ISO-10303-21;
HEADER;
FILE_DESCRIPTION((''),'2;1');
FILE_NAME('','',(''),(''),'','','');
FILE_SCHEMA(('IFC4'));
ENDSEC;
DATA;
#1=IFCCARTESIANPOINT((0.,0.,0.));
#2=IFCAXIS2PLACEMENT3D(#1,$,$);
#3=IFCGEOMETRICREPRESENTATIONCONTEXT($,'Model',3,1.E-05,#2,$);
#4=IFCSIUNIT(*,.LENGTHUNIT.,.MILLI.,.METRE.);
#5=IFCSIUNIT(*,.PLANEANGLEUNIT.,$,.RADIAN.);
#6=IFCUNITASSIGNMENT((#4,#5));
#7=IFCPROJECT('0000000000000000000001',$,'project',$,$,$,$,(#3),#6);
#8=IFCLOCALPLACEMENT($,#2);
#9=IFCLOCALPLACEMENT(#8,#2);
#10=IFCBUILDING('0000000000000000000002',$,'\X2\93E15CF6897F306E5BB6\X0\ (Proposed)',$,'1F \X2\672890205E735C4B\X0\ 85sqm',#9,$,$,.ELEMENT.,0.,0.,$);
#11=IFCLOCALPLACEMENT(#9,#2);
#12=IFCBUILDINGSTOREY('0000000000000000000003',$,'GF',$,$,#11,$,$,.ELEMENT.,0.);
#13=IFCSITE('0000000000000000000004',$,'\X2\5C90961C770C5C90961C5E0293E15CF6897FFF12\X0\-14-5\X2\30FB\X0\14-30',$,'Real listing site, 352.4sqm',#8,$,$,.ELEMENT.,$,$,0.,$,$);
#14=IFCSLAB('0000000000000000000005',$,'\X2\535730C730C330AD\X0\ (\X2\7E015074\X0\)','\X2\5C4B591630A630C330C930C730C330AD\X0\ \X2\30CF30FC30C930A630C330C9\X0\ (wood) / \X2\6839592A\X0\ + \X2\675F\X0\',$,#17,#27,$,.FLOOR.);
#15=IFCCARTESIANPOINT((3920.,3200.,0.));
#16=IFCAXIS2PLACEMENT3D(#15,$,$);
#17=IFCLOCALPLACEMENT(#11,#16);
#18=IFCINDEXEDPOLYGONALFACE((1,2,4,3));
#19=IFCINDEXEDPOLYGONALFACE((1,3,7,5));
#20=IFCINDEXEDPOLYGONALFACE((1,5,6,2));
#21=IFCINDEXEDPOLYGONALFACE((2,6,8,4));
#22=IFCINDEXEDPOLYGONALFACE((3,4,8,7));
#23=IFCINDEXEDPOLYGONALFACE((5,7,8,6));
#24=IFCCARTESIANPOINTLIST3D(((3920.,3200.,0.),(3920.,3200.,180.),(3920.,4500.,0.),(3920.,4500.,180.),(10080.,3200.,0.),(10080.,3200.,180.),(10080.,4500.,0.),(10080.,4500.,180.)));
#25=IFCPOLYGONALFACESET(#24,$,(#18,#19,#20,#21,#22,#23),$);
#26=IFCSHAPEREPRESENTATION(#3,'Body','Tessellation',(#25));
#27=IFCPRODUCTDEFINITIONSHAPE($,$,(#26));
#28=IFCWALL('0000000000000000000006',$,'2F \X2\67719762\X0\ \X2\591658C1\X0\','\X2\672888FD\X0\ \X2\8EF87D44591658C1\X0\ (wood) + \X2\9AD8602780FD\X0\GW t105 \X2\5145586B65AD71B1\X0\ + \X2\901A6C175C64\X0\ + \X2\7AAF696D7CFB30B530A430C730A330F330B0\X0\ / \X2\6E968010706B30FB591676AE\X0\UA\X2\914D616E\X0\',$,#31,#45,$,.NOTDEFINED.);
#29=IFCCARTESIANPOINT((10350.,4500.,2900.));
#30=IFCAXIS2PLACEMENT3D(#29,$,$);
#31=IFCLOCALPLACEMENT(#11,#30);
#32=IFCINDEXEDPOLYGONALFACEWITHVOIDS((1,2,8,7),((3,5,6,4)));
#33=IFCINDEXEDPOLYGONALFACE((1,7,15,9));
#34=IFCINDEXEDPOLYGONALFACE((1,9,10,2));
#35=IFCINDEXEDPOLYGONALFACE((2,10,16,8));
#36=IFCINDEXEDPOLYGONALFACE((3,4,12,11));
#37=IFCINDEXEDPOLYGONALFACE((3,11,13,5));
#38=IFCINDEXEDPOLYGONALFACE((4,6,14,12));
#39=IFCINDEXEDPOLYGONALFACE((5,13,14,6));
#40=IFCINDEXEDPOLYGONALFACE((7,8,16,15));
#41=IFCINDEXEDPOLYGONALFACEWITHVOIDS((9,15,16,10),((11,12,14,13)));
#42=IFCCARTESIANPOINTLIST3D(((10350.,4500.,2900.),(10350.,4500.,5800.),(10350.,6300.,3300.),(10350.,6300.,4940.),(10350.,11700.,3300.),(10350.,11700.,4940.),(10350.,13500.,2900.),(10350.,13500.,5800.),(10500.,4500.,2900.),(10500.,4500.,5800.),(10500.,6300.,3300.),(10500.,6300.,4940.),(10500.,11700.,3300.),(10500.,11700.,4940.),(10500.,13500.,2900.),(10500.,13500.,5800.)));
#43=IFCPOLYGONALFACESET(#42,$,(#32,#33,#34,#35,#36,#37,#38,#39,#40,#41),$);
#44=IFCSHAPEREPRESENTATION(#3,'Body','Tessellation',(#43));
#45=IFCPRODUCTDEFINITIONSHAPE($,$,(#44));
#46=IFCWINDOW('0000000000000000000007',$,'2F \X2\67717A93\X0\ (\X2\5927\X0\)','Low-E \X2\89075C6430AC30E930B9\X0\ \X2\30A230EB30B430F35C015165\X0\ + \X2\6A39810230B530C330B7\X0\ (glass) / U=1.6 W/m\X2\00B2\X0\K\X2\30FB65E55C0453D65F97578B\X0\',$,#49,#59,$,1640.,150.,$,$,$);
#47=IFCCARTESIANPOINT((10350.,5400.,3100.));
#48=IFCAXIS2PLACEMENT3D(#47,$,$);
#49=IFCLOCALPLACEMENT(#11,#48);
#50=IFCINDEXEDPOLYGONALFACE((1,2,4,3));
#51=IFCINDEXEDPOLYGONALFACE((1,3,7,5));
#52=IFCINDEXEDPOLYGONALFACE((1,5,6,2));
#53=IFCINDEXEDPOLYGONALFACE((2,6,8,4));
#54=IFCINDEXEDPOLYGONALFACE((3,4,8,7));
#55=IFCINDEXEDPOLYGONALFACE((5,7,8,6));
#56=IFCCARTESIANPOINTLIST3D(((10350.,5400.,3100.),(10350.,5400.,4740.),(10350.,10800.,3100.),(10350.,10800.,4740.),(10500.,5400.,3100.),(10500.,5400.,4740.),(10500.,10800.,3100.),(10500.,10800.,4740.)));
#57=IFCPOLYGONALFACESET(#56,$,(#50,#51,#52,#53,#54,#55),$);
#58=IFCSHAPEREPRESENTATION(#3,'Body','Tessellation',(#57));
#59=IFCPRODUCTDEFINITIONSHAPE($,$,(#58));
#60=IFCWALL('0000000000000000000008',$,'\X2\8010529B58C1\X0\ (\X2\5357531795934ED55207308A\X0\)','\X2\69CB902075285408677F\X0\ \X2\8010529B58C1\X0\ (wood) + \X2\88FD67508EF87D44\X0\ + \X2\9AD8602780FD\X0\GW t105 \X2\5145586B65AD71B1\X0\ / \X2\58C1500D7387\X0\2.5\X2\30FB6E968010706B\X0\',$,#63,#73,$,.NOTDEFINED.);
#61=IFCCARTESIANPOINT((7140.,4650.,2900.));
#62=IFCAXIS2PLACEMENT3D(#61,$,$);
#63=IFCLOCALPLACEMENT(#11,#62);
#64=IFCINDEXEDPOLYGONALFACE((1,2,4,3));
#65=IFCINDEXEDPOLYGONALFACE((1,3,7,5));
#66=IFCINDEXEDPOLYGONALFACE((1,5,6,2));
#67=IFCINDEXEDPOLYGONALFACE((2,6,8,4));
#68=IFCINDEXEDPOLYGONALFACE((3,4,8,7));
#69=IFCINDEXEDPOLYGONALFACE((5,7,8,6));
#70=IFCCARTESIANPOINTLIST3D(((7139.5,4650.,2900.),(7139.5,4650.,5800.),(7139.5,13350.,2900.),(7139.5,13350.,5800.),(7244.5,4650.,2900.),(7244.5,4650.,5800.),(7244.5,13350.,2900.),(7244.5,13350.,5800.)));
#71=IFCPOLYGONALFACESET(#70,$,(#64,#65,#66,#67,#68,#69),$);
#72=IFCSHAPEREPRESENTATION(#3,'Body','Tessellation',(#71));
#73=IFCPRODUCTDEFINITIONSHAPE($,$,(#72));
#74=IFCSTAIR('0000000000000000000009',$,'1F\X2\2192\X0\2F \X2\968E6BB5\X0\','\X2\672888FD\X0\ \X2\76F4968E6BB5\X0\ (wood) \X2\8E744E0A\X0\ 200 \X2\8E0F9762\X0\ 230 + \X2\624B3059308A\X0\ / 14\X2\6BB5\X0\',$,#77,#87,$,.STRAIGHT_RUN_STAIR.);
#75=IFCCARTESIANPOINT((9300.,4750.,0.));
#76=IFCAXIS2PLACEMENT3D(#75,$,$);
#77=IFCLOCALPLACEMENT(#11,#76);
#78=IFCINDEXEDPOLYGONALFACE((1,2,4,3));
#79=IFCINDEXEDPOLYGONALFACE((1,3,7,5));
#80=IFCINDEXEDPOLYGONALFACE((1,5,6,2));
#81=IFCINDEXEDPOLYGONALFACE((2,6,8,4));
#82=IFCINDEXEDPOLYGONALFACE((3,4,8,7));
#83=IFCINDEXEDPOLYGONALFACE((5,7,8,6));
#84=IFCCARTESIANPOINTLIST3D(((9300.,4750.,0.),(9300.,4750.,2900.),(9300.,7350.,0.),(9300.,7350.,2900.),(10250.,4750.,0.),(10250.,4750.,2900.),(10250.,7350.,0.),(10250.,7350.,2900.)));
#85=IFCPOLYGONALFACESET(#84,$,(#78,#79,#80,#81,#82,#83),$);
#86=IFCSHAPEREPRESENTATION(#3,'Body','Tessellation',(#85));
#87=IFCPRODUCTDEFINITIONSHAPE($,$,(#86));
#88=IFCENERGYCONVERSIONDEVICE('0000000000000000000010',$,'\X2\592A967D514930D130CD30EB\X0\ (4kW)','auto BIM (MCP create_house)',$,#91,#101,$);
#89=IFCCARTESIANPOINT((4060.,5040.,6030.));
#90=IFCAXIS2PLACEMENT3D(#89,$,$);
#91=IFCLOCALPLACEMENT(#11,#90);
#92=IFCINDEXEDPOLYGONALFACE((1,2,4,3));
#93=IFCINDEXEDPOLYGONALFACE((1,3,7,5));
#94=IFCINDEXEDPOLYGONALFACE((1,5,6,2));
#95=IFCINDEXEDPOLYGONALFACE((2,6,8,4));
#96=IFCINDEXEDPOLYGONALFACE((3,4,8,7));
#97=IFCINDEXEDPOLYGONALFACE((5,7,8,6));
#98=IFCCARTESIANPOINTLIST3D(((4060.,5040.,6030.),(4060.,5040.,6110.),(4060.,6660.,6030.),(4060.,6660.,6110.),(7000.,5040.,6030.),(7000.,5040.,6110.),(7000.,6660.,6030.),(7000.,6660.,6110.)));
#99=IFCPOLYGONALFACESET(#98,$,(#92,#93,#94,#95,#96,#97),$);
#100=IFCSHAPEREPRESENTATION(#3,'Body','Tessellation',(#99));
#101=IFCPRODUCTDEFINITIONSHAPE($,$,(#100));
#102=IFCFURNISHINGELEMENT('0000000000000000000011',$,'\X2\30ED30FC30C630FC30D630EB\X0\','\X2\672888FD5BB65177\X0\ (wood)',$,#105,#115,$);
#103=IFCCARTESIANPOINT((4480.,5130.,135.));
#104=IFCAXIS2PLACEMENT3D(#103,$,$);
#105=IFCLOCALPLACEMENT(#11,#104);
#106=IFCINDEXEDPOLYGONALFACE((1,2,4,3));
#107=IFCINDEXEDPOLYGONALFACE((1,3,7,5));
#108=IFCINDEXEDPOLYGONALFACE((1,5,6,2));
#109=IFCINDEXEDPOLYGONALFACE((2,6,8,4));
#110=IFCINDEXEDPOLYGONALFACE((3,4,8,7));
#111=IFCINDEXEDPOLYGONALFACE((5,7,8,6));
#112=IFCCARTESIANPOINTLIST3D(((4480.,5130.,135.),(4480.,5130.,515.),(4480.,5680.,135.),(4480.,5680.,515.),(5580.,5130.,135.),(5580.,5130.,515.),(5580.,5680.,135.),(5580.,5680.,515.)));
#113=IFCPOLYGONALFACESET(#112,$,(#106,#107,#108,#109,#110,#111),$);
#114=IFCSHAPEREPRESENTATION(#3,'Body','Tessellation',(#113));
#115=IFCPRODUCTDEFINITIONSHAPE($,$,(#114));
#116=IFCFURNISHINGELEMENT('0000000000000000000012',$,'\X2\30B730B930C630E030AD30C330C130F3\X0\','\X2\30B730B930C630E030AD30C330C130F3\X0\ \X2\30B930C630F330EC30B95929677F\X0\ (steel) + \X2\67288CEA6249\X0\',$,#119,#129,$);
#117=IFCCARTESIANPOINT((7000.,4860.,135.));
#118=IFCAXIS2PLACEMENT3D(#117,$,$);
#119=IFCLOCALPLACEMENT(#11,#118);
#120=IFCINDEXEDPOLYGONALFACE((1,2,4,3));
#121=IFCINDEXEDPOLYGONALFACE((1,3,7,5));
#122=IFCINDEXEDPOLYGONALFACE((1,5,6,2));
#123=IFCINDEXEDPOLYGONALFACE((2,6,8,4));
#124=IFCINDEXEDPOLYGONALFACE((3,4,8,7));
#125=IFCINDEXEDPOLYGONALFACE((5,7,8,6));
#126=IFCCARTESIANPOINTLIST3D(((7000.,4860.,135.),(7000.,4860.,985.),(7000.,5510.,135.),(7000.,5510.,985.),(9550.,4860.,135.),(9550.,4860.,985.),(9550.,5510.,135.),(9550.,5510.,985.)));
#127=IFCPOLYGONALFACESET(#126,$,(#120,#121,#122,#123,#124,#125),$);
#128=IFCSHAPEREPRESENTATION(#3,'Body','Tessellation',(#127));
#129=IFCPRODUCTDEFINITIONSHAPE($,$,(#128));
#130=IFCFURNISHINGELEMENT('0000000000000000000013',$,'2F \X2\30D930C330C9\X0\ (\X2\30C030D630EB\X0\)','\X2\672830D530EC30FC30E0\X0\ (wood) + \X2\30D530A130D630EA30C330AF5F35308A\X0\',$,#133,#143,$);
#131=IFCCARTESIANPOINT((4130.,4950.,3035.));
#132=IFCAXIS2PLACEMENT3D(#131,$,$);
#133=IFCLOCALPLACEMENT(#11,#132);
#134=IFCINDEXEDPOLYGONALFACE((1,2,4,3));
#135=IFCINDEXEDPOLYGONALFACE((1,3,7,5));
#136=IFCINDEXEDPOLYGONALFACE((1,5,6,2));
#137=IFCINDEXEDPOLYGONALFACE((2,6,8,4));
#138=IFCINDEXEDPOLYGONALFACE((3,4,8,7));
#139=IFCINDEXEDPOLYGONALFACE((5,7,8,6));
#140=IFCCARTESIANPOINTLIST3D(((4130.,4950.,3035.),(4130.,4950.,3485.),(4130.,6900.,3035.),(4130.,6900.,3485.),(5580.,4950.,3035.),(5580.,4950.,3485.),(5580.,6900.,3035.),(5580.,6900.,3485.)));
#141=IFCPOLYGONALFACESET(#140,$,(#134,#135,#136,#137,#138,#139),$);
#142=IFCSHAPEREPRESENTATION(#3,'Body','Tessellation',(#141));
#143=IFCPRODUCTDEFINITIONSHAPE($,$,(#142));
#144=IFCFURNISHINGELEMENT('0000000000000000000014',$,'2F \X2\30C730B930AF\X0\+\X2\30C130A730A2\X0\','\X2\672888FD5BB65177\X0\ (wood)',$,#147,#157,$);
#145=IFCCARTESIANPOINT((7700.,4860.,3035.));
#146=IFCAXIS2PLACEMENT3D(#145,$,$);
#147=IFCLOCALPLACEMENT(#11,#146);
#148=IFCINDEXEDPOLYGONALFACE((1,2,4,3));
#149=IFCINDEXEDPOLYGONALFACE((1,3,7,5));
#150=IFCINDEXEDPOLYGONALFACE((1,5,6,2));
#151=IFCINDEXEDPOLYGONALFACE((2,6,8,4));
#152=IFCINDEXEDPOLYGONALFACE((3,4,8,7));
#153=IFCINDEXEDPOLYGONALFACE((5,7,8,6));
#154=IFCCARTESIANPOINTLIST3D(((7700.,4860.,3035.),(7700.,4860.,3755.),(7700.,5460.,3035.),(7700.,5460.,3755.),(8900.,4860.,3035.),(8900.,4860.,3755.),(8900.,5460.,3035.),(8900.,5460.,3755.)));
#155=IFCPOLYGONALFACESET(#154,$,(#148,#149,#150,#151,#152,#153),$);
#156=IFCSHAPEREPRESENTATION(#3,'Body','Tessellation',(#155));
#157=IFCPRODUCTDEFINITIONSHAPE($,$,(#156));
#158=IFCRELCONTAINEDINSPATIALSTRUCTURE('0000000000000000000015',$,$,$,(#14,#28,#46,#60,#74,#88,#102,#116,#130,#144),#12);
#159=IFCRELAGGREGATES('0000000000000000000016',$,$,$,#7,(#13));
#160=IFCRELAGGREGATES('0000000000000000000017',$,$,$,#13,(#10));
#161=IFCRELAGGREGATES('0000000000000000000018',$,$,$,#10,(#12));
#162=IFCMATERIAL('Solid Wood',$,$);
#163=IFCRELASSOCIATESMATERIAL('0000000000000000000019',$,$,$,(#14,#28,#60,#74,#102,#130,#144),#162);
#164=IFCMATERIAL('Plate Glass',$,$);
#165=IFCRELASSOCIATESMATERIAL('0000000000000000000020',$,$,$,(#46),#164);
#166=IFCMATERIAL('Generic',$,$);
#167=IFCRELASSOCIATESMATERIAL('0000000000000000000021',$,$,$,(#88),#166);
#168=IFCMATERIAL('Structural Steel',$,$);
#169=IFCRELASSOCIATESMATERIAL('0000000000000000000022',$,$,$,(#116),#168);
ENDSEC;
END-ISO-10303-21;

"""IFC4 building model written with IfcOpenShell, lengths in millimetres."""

from ifc_helpers import new_model, si_unit, frame, frame_2d, origin, place, context, project, spatial, rectangle, extrude, material, element, fill, save


model = new_model("IFC4")

# Units and contexts
model_context = context("Model", 3, precision=1e-05, world=origin())
ifc_project = project(units=[si_unit("LENGTHUNIT", "METRE", prefix="MILLI"), si_unit("PLANEANGLEUNIT", "RADIAN")], contexts=[model_context])

# Site, building, storey
site_placement = place(None, origin())
site = spatial("IfcSite", under=ifc_project, at=site_placement, Name="岐阜県岐阜市鏡島西２-14-5・14-30", ObjectType="Real listing site, 352.4sqm", CompositionType="ELEMENT", RefElevation=0.0)
building_placement = place(site_placement, origin())
building = spatial("IfcBuilding", under=site, at=building_placement, Name="鏡島西の家 (Proposed)", ObjectType="1F 木造平屋 85sqm", CompositionType="ELEMENT", ElevationOfRefHeight=0.0, ElevationOfTerrain=0.0)
storey_placement = place(building_placement, origin())
storey = spatial("IfcBuildingStorey", under=building, at=storey_placement, Name="GF", CompositionType="ELEMENT", Elevation=0.0)

# Slab
ifc_material_1 = material(Name="Solid Wood")
slab_placement = place(storey_placement, frame((3920.0, 3200.0, 0.0)))
element("IfcSlab", 1, at=slab_placement, inside=storey, material=ifc_material_1, Name="南デッキ (縁側)", Description="屋外ウッドデッキ ハードウッド (wood) / 根太 + 束", PredefinedType="FLOOR", context=model_context, shape_type="SweptSolid", body=[
    extrude(rectangle(XDim=6160.0, YDim=1300.0, at=frame_2d((3080.0, 650.0))), frame((3920.0, 3200.0, 0.0)), (0.0, 0.0, 1.0), 180.0),
])

# Shared definitions
ifc_material_2 = material(Name="Plate Glass")

# Wall, opening, window
wall_1_placement = place(storey_placement, frame((10350.0, 4500.0, 2900.0)))
wall_1 = element("IfcWall", 2, at=wall_1_placement, inside=storey, material=ifc_material_1, Name="2F 東面 外壁", Description="木製 軸組外壁 (wood) + 高性能GW t105 充填断熱 + 通気層 + 窯業系サイディング / 準耐火・外皮UA配慮", PredefinedType="NOTDEFINED", context=model_context, shape_type="SweptSolid", body=[
    extrude(rectangle(XDim=150.0, YDim=9000.0, at=frame_2d((75.0, 4500.0))), frame((10350.0, 4500.0, 2900.0)), (0.0, 0.0, 1.0), 2900.0),
])
opening_1_placement = place(storey_placement, frame((10350.0, 5400.0, 3100.0)))
opening_1 = element("IfcOpeningElement", 3, at=opening_1_placement, cuts=wall_1, PredefinedType="NOTDEFINED", context=model_context, shape_type="SweptSolid", body=[
    extrude(rectangle(XDim=150.0, YDim=5400.0, at=frame_2d((75.0, 2700.0))), frame((10350.0, 5400.0, 3100.0)), (0.0, 0.0, 1.0), 1640.0),
])
window_1_placement = place(storey_placement, frame((10350.0, 5400.0, 3100.0)))
window_1 = element("IfcWindow", 4, at=window_1_placement, inside=storey, material=ifc_material_2, Name="2F 東窓 (大)", Description="Low-E 複層ガラス アルゴン封入 + 樹脂サッシ (glass) / U=1.6 W/m²K・日射取得型", OverallHeight=1640.0, OverallWidth=150.0, context=model_context, shape_type="SweptSolid", body=[
    extrude(rectangle(XDim=150.0, YDim=5400.0, at=frame_2d((75.0, 2700.0))), frame((10350.0, 5400.0, 3100.0)), (0.0, 0.0, 1.0), 1640.0),
])
fill(opening_1, window_1)

# Wall
wall_2_placement = place(storey_placement, frame((7140.0, 4650.0, 2900.0)))
element("IfcWall", 5, at=wall_2_placement, inside=storey, material=ifc_material_1, Name="耐力壁 (南北間仕切り)", Description="構造用合板 耐力壁 (wood) + 製材軸組 + 高性能GW t105 充填断熱 / 壁倍率2.5・準耐火", PredefinedType="NOTDEFINED", context=model_context, shape_type="SweptSolid", body=[
    extrude(rectangle(XDim=105.0, YDim=8700.0, at=frame_2d((52.0, 4350.0))), frame((7140.0, 4650.0, 2900.0)), (0.0, 0.0, 1.0), 2900.0),
])

# Stair
stair_placement = place(storey_placement, frame((9300.0, 4750.0, 0.0)))
element("IfcStair", 6, at=stair_placement, inside=storey, material=ifc_material_1, Name="1F→2F 階段", Description="木製 直階段 (wood) 蹴上 200 踏面 230 + 手すり / 14段", PredefinedType="STRAIGHT_RUN_STAIR", context=model_context, shape_type="SweptSolid", body=[
    extrude(rectangle(XDim=950.0, YDim=2600.0, at=frame_2d((475.0, 1300.0))), frame((9300.0, 4750.0, 0.0)), (0.0, 0.0, 1.0), 2900.0),
])

# Energy conversion device
ifc_material_3 = material(Name="Generic")
energy_conversion_device_placement = place(storey_placement, frame((4060.0, 5040.0, 6030.0)))
element("IfcEnergyConversionDevice", 7, at=energy_conversion_device_placement, inside=storey, material=ifc_material_3, Name="太陽光パネル (4kW)", Description="auto BIM (MCP create_house)", context=model_context, shape_type="SweptSolid", body=[
    extrude(rectangle(XDim=2940.0, YDim=1620.0, at=frame_2d((1470.0, 810.0))), frame((4060.0, 5040.0, 6030.0)), (0.0, 0.0, 1.0), 80.0),
])

# Furnishing elements
furnishing_1_placement = place(storey_placement, frame((4480.0, 5130.0, 135.0)))
element("IfcFurnishingElement", 8, at=furnishing_1_placement, inside=storey, material=ifc_material_1, Name="ローテーブル", Description="木製家具 (wood)", context=model_context, shape_type="SweptSolid", body=[
    extrude(rectangle(XDim=1100.0, YDim=550.0, at=frame_2d((550.0, 275.0))), frame((4480.0, 5130.0, 135.0)), (0.0, 0.0, 1.0), 380.0),
])
ifc_material_4 = material(Name="Structural Steel")
furnishing_2_placement = place(storey_placement, frame((7000.0, 4860.0, 135.0)))
element("IfcFurnishingElement", 9, at=furnishing_2_placement, inside=storey, material=ifc_material_4, Name="システムキッチン", Description="システムキッチン ステンレス天板 (steel) + 木質扉", context=model_context, shape_type="SweptSolid", body=[
    extrude(rectangle(XDim=2550.0, YDim=650.0, at=frame_2d((1275.0, 325.0))), frame((7000.0, 4860.0, 135.0)), (0.0, 0.0, 1.0), 850.0),
])
furnishing_3_placement = place(storey_placement, frame((4130.0, 4950.0, 3035.0)))
element("IfcFurnishingElement", 10, at=furnishing_3_placement, inside=storey, material=ifc_material_1, Name="2F ベッド (ダブル)", Description="木フレーム (wood) + ファブリック張り", context=model_context, shape_type="SweptSolid", body=[
    extrude(rectangle(XDim=1450.0, YDim=1950.0, at=frame_2d((725.0, 975.0))), frame((4130.0, 4950.0, 3035.0)), (0.0, 0.0, 1.0), 450.0),
])
furnishing_4_placement = place(storey_placement, frame((7700.0, 4860.0, 3035.0)))
element("IfcFurnishingElement", 11, at=furnishing_4_placement, inside=storey, material=ifc_material_1, Name="2F デスク+チェア", Description="木製家具 (wood)", context=model_context, shape_type="SweptSolid", body=[
    extrude(rectangle(XDim=1200.0, YDim=600.0, at=frame_2d((600.0, 300.0))), frame((7700.0, 4860.0, 3035.0)), (0.0, 0.0, 1.0), 720.0),
])

save(model, "model.ifc")
